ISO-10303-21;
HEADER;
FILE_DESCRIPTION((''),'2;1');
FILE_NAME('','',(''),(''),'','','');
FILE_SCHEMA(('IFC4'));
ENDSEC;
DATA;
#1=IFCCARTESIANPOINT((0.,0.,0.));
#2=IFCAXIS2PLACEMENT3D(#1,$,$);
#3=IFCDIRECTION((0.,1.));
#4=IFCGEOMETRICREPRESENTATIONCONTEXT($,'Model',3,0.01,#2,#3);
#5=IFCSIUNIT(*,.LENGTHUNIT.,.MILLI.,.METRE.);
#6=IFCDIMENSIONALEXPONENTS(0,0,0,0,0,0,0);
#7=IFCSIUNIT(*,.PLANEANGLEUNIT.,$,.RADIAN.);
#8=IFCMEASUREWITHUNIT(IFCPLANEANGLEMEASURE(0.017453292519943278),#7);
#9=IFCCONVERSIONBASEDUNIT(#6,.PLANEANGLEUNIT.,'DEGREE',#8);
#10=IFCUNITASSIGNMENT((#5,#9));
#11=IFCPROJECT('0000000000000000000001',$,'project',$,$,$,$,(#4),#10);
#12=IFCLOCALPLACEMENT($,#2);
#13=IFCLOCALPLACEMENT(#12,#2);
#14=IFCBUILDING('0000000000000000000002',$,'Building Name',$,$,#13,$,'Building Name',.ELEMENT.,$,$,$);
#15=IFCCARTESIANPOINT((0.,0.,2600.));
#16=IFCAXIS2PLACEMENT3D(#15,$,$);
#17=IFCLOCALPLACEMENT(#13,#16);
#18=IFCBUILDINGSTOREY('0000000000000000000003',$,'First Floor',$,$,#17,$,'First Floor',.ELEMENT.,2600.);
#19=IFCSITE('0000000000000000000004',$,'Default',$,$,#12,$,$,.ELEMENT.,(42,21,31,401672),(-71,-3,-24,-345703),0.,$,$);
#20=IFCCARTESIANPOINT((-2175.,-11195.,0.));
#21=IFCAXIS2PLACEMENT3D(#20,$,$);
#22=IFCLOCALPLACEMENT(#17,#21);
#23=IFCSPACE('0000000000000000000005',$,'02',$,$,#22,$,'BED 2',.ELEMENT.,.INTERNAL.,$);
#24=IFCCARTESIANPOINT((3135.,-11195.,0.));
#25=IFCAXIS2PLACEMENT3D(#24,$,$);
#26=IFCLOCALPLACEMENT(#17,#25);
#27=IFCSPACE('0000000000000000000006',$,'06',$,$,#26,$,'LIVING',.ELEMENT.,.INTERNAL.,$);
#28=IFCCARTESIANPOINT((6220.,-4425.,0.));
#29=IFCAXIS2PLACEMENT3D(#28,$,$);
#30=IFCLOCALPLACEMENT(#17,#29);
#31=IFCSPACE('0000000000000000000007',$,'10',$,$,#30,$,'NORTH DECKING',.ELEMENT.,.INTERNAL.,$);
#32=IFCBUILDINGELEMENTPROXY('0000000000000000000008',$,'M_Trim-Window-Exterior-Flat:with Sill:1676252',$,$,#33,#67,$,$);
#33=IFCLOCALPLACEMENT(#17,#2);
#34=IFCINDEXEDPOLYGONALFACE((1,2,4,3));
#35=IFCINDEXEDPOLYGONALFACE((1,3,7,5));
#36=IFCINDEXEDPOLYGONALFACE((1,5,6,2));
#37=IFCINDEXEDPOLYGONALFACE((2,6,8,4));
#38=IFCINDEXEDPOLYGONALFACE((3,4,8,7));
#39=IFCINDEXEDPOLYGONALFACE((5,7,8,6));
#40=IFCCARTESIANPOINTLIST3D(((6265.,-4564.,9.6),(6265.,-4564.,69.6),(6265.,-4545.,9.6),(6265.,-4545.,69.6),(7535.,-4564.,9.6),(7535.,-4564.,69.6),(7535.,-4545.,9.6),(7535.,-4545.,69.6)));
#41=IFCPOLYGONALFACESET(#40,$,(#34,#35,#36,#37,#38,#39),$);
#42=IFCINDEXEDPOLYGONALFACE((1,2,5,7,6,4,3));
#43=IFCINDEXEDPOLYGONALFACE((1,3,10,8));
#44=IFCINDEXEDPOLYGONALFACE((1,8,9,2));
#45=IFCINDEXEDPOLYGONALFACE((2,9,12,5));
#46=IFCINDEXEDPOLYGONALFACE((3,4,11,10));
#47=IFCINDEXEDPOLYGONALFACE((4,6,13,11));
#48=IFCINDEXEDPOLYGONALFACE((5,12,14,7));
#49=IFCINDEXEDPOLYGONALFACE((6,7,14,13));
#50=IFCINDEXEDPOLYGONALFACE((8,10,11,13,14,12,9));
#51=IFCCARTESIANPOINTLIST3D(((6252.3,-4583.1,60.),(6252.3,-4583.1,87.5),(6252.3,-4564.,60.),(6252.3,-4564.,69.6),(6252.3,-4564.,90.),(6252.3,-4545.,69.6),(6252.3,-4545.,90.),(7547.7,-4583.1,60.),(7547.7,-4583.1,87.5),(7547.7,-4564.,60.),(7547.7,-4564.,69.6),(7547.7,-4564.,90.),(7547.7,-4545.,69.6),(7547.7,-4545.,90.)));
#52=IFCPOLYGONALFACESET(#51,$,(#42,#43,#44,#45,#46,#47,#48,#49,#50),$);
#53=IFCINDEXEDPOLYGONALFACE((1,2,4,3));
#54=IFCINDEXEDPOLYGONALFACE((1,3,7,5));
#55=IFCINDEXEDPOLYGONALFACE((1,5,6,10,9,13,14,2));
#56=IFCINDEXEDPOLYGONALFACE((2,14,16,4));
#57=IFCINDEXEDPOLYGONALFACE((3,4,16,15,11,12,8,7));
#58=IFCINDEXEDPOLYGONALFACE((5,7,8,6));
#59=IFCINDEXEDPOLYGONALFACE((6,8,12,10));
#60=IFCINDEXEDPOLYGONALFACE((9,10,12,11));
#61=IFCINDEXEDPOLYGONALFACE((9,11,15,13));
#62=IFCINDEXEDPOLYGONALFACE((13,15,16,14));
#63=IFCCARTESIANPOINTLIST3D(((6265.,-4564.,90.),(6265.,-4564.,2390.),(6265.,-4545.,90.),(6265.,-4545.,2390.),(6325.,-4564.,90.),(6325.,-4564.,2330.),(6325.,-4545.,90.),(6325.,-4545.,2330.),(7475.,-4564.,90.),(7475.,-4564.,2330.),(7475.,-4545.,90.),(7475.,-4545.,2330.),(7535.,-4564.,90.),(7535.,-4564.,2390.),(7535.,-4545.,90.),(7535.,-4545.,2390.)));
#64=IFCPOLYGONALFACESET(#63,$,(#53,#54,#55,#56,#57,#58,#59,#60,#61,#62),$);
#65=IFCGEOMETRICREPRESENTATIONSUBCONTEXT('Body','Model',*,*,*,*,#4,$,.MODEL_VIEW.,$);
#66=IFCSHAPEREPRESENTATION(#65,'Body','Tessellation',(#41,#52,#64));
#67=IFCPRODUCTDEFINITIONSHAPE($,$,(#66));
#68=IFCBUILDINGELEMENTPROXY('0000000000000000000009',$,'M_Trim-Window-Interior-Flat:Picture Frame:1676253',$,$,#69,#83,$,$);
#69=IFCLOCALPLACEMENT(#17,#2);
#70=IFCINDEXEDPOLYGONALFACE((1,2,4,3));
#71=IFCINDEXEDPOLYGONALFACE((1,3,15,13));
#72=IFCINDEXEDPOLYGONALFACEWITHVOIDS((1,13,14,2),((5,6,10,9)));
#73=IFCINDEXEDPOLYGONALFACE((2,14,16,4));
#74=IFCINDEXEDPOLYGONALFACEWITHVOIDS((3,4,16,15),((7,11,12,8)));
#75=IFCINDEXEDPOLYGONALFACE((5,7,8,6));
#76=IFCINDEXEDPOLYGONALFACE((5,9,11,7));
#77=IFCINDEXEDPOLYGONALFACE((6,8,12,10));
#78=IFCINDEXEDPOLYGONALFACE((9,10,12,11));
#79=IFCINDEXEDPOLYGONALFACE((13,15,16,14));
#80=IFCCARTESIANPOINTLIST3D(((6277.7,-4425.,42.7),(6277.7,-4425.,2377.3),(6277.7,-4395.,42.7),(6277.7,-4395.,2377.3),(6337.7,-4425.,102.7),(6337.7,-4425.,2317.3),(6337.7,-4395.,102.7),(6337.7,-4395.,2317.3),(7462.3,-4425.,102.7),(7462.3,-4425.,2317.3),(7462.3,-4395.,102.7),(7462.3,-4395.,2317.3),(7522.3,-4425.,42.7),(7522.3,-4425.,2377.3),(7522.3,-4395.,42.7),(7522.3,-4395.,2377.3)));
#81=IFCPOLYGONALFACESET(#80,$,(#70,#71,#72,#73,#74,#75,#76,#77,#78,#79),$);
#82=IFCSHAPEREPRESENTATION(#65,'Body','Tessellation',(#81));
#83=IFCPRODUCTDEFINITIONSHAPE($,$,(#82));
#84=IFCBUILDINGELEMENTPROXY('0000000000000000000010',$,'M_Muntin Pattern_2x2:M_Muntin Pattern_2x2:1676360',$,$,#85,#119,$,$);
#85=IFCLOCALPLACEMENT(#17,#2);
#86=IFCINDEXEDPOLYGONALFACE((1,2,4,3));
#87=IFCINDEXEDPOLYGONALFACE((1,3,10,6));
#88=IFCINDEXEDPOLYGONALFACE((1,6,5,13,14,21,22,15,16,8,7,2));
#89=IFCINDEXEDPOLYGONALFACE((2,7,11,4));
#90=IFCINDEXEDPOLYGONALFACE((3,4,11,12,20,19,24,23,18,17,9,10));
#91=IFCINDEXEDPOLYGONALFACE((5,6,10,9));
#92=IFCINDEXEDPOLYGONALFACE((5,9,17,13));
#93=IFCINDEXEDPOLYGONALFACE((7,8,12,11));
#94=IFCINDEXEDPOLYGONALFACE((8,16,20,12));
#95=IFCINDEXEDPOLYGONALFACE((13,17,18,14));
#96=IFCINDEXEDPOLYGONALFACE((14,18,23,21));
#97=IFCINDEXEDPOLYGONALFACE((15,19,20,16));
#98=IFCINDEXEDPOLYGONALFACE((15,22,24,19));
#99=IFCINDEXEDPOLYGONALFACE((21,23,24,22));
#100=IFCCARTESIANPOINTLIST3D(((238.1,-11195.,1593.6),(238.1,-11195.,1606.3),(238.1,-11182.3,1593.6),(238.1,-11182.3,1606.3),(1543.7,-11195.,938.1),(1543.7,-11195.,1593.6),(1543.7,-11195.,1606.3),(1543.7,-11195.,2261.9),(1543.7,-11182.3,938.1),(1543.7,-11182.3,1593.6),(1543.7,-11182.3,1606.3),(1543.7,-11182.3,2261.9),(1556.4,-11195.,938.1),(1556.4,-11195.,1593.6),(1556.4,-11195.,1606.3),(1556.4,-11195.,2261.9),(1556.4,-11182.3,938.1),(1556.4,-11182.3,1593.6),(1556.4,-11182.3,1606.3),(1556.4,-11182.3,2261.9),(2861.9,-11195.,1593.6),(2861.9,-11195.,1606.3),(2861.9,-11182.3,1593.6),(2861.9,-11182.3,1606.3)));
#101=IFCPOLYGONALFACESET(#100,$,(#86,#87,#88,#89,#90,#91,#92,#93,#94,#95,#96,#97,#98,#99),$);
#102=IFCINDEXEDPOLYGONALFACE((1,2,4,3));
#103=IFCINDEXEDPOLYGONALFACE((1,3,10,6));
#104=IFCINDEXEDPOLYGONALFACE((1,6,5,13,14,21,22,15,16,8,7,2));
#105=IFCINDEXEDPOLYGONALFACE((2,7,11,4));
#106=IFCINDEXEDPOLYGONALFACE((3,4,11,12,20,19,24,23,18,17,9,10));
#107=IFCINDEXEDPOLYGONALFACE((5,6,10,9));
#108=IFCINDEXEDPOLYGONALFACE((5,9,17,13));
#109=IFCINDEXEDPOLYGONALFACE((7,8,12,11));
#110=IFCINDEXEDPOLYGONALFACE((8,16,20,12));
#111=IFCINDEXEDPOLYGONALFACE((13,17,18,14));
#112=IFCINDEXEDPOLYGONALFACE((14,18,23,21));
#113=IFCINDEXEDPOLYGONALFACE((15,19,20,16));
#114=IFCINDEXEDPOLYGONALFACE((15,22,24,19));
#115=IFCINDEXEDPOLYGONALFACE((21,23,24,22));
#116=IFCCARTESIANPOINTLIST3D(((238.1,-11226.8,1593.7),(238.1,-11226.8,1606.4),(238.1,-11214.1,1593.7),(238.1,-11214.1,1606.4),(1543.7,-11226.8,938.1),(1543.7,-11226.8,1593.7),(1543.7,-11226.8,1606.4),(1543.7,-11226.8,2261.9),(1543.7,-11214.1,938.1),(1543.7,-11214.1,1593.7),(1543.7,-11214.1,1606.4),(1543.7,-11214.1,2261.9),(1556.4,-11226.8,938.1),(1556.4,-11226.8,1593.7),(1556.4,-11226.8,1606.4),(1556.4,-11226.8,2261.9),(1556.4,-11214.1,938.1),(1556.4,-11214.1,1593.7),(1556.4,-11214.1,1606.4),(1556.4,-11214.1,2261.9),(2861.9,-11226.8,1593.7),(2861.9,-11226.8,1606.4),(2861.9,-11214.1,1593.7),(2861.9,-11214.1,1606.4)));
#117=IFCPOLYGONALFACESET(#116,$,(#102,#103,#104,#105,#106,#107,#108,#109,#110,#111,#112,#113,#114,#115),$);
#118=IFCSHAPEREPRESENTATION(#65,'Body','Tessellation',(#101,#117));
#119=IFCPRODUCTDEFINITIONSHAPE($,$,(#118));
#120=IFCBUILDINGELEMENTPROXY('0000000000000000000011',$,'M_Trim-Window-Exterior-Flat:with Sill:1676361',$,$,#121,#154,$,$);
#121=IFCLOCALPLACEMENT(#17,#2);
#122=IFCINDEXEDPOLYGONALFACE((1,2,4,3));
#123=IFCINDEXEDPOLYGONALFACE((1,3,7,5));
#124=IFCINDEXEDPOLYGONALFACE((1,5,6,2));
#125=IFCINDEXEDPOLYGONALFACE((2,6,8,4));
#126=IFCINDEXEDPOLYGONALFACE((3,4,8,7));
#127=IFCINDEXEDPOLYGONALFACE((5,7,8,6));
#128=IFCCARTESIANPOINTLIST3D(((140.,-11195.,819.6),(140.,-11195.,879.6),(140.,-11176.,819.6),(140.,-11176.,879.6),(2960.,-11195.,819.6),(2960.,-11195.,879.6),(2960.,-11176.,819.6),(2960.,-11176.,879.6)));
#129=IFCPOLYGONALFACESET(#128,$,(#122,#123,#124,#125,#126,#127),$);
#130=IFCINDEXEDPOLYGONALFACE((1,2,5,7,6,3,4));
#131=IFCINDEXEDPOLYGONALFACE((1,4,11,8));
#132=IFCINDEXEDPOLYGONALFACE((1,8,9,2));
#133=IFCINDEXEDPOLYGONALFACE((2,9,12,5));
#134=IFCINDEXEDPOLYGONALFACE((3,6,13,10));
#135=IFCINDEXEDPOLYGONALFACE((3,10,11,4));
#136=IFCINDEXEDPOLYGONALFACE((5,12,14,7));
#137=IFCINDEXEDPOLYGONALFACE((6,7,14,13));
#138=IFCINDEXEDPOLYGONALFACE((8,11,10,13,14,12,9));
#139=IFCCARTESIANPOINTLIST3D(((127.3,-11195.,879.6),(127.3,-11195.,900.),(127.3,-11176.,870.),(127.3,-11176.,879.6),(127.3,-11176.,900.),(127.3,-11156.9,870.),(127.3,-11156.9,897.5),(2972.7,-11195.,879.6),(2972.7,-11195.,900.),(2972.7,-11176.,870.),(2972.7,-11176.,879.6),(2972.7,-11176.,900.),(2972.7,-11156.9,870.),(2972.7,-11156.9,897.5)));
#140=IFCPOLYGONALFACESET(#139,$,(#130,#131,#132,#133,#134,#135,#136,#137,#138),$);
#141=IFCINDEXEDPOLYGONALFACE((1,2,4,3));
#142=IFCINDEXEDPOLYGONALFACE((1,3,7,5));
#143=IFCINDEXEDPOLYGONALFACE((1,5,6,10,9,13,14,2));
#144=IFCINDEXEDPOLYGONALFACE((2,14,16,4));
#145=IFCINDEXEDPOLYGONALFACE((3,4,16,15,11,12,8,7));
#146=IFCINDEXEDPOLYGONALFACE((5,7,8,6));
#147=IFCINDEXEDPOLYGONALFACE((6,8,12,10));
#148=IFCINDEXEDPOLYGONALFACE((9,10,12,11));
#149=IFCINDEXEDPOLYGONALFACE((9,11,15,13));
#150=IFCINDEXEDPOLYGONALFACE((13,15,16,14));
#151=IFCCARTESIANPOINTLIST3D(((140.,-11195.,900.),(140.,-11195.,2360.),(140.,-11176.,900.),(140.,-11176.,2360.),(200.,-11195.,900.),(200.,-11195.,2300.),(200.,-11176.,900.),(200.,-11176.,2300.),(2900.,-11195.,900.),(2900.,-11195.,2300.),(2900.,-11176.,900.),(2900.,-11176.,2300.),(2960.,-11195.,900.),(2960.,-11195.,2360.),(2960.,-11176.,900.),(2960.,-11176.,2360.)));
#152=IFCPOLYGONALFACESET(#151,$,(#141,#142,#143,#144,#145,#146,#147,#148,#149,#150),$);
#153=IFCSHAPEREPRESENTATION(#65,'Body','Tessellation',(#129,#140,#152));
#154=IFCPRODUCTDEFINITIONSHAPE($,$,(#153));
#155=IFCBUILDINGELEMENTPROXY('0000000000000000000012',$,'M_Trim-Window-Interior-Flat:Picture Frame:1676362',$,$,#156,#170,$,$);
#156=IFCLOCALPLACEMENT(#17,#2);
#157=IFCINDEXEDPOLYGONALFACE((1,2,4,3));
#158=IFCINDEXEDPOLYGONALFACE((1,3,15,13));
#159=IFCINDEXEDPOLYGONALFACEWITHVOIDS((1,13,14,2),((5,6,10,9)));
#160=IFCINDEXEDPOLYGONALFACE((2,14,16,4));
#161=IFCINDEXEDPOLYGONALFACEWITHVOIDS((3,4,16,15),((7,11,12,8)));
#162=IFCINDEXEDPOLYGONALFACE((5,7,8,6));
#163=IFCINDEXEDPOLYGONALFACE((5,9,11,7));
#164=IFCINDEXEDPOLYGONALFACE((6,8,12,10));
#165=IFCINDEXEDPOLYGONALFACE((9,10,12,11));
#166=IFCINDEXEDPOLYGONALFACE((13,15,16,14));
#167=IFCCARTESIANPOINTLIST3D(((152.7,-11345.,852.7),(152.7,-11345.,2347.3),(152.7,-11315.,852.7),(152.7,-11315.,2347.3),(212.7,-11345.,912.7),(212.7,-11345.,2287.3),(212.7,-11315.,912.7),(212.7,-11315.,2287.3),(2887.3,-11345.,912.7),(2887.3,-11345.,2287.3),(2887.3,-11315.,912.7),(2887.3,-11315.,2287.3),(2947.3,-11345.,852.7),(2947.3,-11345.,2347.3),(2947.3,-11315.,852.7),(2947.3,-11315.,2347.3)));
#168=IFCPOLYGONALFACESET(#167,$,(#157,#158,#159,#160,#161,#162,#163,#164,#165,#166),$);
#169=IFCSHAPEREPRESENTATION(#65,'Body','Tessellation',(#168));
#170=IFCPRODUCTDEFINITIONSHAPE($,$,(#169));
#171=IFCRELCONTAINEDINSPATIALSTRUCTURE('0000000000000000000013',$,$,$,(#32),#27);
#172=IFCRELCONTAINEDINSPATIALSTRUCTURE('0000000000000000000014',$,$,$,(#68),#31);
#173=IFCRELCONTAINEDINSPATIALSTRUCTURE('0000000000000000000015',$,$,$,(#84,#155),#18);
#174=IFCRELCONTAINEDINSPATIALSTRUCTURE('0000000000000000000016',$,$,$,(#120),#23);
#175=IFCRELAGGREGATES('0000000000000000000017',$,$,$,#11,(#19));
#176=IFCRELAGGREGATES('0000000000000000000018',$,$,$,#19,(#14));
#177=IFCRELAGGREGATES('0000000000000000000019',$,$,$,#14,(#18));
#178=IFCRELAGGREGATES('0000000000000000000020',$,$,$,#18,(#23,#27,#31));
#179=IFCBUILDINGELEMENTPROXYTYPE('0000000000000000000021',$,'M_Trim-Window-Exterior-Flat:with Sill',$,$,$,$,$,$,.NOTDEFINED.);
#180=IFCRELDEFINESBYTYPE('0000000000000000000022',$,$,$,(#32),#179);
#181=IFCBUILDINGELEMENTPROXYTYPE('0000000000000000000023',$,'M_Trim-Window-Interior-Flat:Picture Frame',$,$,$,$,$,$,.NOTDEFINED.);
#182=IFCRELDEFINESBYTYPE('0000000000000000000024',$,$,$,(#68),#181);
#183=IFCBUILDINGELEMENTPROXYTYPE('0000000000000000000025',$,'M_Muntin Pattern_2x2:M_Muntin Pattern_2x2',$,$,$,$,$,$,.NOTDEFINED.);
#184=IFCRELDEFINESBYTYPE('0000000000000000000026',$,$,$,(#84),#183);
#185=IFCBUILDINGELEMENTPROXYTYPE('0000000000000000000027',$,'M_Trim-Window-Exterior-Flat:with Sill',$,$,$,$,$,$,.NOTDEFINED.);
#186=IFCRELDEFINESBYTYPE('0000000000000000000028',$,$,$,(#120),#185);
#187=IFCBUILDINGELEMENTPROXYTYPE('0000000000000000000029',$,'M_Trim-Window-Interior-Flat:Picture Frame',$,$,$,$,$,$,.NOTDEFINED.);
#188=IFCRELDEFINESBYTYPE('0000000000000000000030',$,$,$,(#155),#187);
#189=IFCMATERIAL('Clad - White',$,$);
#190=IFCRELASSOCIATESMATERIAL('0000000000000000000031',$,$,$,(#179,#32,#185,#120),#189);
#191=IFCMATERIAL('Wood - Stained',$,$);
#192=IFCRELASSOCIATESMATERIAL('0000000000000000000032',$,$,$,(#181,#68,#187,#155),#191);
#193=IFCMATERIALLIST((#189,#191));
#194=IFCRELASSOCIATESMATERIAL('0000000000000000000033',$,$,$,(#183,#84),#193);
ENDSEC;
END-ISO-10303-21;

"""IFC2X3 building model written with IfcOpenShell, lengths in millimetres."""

from ifc_helpers import new_model, entity, si_unit, converted_unit, direction, frame, frame_2d, origin, place, context, subcontext, project, spatial, polyline, rectangle, outline, extrude, source, transform, mapped, material, material_list, type_object, type_shapes, element, save


model = new_model("IFC2X3")

# Units and contexts
model_context = context("Model", 3, precision=0.01, world=origin(), true_north=direction((0.0, 1.0)))
body_context = subcontext(model_context, "Body", "Model", "MODEL_VIEW")
ifc_project = project(units=[si_unit("LENGTHUNIT", "METRE", prefix="MILLI"), converted_unit("PLANEANGLEUNIT", "DEGREE", entity("IfcPlaneAngleMeasure", 0.017453292519943278), si_unit("PLANEANGLEUNIT", "RADIAN"), dimensions=[0, 0, 0, 0, 0, 0, 0])], contexts=[model_context])

# Site, building, storey
site_placement = place(None, origin())
site = spatial("IfcSite", under=ifc_project, at=site_placement, Name="Default", CompositionType="ELEMENT", RefLatitude=(42, 21, 31, 401672), RefLongitude=(-71, -3, -24, -345703), RefElevation=0.0)
building_placement = place(site_placement, origin())
building = spatial("IfcBuilding", under=site, at=building_placement, Name="Building Name", LongName="Building Name", CompositionType="ELEMENT")
storey_placement = place(building_placement, frame((0.0, 0.0, 2600.0)))
storey = spatial("IfcBuildingStorey", under=building, at=storey_placement, Name="First Floor", LongName="First Floor", CompositionType="ELEMENT", Elevation=2600.0)

# Shared definitions
space_1_placement = place(storey_placement, frame((-2175.0, -11195.0, 0.0)))
space_1 = spatial("IfcSpace", under=storey, at=space_1_placement, Name="02", LongName="BED 2", CompositionType="ELEMENT", InteriorOrExteriorSpace="INTERNAL")

# Shared definitions
space_2_placement = place(storey_placement, frame((3135.0, -11195.0, 0.0)))
space_2 = spatial("IfcSpace", under=storey, at=space_2_placement, Name="06", LongName="LIVING", CompositionType="ELEMENT", InteriorOrExteriorSpace="INTERNAL")

# Building element proxy
ifc_material_1 = material(Name="Clad - White")
ifc_material_2 = material(Name="Wood - Stained")
ifc_material_list_1 = material_list([ifc_material_1, ifc_material_2])
building_element_proxy_type_1 = type_object("IfcBuildingElementProxyType", Name="M_Trim-Window-Exterior-Flat:with Sill", PredefinedType="NOTDEFINED", material=ifc_material_1)
shared_shape_1 = source(origin(), body_context, "Body", "SweptSolid", [
    extrude(rectangle(XDim=1270.0, YDim=60.0, at=frame_2d((0.0, 0.0), x_axis=(1.0, 0.0))), frame((0.0, -2290.4, 0.0), z_axis=(0.0, 0.0, 1.0), x_axis=(-1.0, 0.0, 0.0)), (0.0, 0.0, 1.0), 19.0),
    extrude(outline(polyline([(-19.0, -15.2), (0.0, -15.2), (0.0, -5.7), (19.0, -5.7), (19.0, 14.8), (0.0, 14.8), (-19.0, 12.3), (-19.0, -15.2)])), frame((-647.7, -2254.8, 19.0), z_axis=(1.0, 0.0, 0.0), x_axis=(0.0, 0.0, -1.0)), (0.0, 0.0, 1.0), 1295.4),
    extrude(outline(polyline([(-1165.0, -635.0), (1135.0, -635.0), (1135.0, -575.0), (-1105.0, -575.0), (-1105.0, 575.0), (1135.0, 575.0), (1135.0, 635.0), (-1165.0, 635.0), (-1165.0, -635.0)])), frame((0.0, -1105.0, 0.0), z_axis=(0.0, 0.0, 1.0), x_axis=(0.0, -1.0, 0.0)), (0.0, 0.0, 1.0), 19.0),
])
type_shapes(building_element_proxy_type_1, [shared_shape_1])
proxy_1_placement = place(space_2_placement, frame((3765.0, 6650.0, 2330.0), z_axis=(0.0, -1.0, 0.0), x_axis=(1.0, 0.0, 0.0)))
element("IfcBuildingElementProxy", 1, at=proxy_1_placement, inside=space_2, type_object=building_element_proxy_type_1, material=ifc_material_1, Name="M_Trim-Window-Exterior-Flat:with Sill:1676252", context=body_context, shape_type="MappedRepresentation", body=[
    mapped(shared_shape_1, transform((0.0, 0.0, 0.0), scale=1.0)),
])

# Shared definitions
space_3_placement = place(storey_placement, frame((6220.0, -4425.0, 0.0)))
space_3 = spatial("IfcSpace", under=storey, at=space_3_placement, Name="10", LongName="NORTH DECKING", CompositionType="ELEMENT", InteriorOrExteriorSpace="INTERNAL")

# Building element proxies
building_element_proxy_type_2 = type_object("IfcBuildingElementProxyType", Name="M_Trim-Window-Interior-Flat:Picture Frame", PredefinedType="NOTDEFINED", material=ifc_material_2)
shared_shape_2 = source(origin(), body_context, "Body", "SweptSolid", [
    extrude(outline(polyline([(-622.3, -1167.3), (622.3, -1167.3), (622.3, 1167.3), (-622.3, 1167.3), (-622.3, -1167.3)]), holes=[polyline([(-562.3, -1107.3), (-562.3, 1107.3), (562.3, 1107.3), (562.3, -1107.3), (-562.3, -1107.3)])]), frame((0.0, -1120.0, 0.0), z_axis=(0.0, 0.0, 1.0), x_axis=(-1.0, 0.0, 0.0)), (0.0, 0.0, 1.0), 30.0),
])
type_shapes(building_element_proxy_type_2, [shared_shape_2])
proxy_2_placement = place(space_3_placement, frame((680.0, 0.0, 2330.0), z_axis=(0.0, 1.0, 0.0), x_axis=(-1.0, 0.0, 0.0)))
element("IfcBuildingElementProxy", 2, at=proxy_2_placement, inside=space_3, type_object=building_element_proxy_type_2, material=ifc_material_2, Name="M_Trim-Window-Interior-Flat:Picture Frame:1676253", context=body_context, shape_type="MappedRepresentation", body=[
    mapped(shared_shape_2, transform((0.0, 0.0, 0.0), scale=1.0)),
])
building_element_proxy_type_3 = type_object("IfcBuildingElementProxyType", Name="M_Muntin Pattern_2x2:M_Muntin Pattern_2x2", PredefinedType="NOTDEFINED", material=ifc_material_list_1)
shared_shape_3 = source(origin(), body_context, "Body", "SweptSolid", [
    extrude(outline(polyline([(6.4, -6.4), (661.9, -6.4), (661.9, 6.3), (6.4, 6.3), (6.4, 1311.9), (-6.3, 1311.9), (-6.3, 6.3), (-661.9, 6.3), (-661.9, -6.4), (-6.3, -6.4), (-6.3, -1311.9), (6.4, -1311.9), (6.4, -6.4)])), frame((0.0, -22.2, 661.9), z_axis=(0.0, 1.0, 0.0), x_axis=(0.0, 0.0, 1.0)), (0.0, 0.0, 1.0), 12.7),
    extrude(outline(polyline([(6.4, -6.4), (661.9, -6.4), (661.9, 6.3), (6.4, 6.3), (6.4, 1311.9), (-6.3, 1311.9), (-6.3, 6.3), (-661.9, 6.3), (-661.9, -6.4), (-6.3, -6.4), (-6.3, -1311.9), (6.4, -1311.9), (6.4, -6.4)])), frame((0.0, 9.5, 661.9), z_axis=(0.0, 1.0, 0.0), x_axis=(0.0, 0.0, 1.0)), (0.0, 0.0, 1.0), 12.7),
])
type_shapes(building_element_proxy_type_3, [shared_shape_3])
proxy_3_placement = place(storey_placement, frame((1550.0, -11204.5, 938.1), z_axis=(0.0, 0.0, 1.0), x_axis=(-1.0, 0.0, 0.0)))
element("IfcBuildingElementProxy", 3, at=proxy_3_placement, inside=storey, type_object=building_element_proxy_type_3, material=ifc_material_list_1, Name="M_Muntin Pattern_2x2:M_Muntin Pattern_2x2:1676360", context=body_context, shape_type="MappedRepresentation", body=[
    mapped(shared_shape_3, transform((0.0, 0.0, 0.0), scale=1.0)),
])
building_element_proxy_type_4 = type_object("IfcBuildingElementProxyType", Name="M_Trim-Window-Exterior-Flat:with Sill", PredefinedType="NOTDEFINED", material=ifc_material_1)
shared_shape_4 = source(origin(), body_context, "Body", "SweptSolid", [
    extrude(rectangle(XDim=2820.0, YDim=60.0, at=frame_2d((0.0, 0.0), x_axis=(1.0, 0.0))), frame((0.0, -1450.4, 0.0), z_axis=(0.0, 0.0, 1.0), x_axis=(-1.0, 0.0, 0.0)), (0.0, 0.0, 1.0), 19.0),
    extrude(outline(polyline([(-19.0, -15.2), (0.0, -15.2), (0.0, -5.7), (19.0, -5.7), (19.0, 14.8), (0.0, 14.8), (-19.0, 12.3), (-19.0, -15.2)])), frame((-1422.7, -1414.8, 19.0), z_axis=(1.0, 0.0, 0.0), x_axis=(0.0, 0.0, -1.0)), (0.0, 0.0, 1.0), 2845.4),
    extrude(outline(polyline([(-745.0, -1410.0), (715.0, -1410.0), (715.0, -1350.0), (-685.0, -1350.0), (-685.0, 1350.0), (715.0, 1350.0), (715.0, 1410.0), (-745.0, 1410.0), (-745.0, -1410.0)])), frame((0.0, -685.0, 0.0), z_axis=(0.0, 0.0, 1.0), x_axis=(0.0, -1.0, 0.0)), (0.0, 0.0, 1.0), 19.0),
])
type_shapes(building_element_proxy_type_4, [shared_shape_4])
proxy_4_placement = place(space_1_placement, frame((3725.0, 0.0, 2300.0), z_axis=(0.0, 1.0, 0.0), x_axis=(-1.0, 0.0, 0.0)))
element("IfcBuildingElementProxy", 4, at=proxy_4_placement, inside=space_1, type_object=building_element_proxy_type_4, material=ifc_material_1, Name="M_Trim-Window-Exterior-Flat:with Sill:1676361", context=body_context, shape_type="MappedRepresentation", body=[
    mapped(shared_shape_4, transform((0.0, 0.0, 0.0), scale=1.0)),
])
building_element_proxy_type_5 = type_object("IfcBuildingElementProxyType", Name="M_Trim-Window-Interior-Flat:Picture Frame", PredefinedType="NOTDEFINED", material=ifc_material_2)
shared_shape_5 = source(origin(), body_context, "Body", "SweptSolid", [
    extrude(outline(polyline([(-1397.3, -747.3), (1397.3, -747.3), (1397.3, 747.3), (-1397.3, 747.3), (-1397.3, -747.3)]), holes=[polyline([(-1337.3, -687.3), (-1337.3, 687.3), (1337.3, 687.3), (1337.3, -687.3), (-1337.3, -687.3)])]), frame((0.0, -700.0, 0.0), z_axis=(0.0, 0.0, 1.0), x_axis=(-1.0, 0.0, 0.0)), (0.0, 0.0, 1.0), 30.0),
])
type_shapes(building_element_proxy_type_5, [shared_shape_5])
proxy_5_placement = place(storey_placement, frame((1550.0, -11315.0, 2300.0), z_axis=(0.0, -1.0, 0.0), x_axis=(1.0, 0.0, 0.0)))
element("IfcBuildingElementProxy", 5, at=proxy_5_placement, inside=storey, type_object=building_element_proxy_type_5, material=ifc_material_2, Name="M_Trim-Window-Interior-Flat:Picture Frame:1676362", context=body_context, shape_type="MappedRepresentation", body=[
    mapped(shared_shape_5, transform((0.0, 0.0, 0.0), scale=1.0)),
])

save(model, "model.ifc")
